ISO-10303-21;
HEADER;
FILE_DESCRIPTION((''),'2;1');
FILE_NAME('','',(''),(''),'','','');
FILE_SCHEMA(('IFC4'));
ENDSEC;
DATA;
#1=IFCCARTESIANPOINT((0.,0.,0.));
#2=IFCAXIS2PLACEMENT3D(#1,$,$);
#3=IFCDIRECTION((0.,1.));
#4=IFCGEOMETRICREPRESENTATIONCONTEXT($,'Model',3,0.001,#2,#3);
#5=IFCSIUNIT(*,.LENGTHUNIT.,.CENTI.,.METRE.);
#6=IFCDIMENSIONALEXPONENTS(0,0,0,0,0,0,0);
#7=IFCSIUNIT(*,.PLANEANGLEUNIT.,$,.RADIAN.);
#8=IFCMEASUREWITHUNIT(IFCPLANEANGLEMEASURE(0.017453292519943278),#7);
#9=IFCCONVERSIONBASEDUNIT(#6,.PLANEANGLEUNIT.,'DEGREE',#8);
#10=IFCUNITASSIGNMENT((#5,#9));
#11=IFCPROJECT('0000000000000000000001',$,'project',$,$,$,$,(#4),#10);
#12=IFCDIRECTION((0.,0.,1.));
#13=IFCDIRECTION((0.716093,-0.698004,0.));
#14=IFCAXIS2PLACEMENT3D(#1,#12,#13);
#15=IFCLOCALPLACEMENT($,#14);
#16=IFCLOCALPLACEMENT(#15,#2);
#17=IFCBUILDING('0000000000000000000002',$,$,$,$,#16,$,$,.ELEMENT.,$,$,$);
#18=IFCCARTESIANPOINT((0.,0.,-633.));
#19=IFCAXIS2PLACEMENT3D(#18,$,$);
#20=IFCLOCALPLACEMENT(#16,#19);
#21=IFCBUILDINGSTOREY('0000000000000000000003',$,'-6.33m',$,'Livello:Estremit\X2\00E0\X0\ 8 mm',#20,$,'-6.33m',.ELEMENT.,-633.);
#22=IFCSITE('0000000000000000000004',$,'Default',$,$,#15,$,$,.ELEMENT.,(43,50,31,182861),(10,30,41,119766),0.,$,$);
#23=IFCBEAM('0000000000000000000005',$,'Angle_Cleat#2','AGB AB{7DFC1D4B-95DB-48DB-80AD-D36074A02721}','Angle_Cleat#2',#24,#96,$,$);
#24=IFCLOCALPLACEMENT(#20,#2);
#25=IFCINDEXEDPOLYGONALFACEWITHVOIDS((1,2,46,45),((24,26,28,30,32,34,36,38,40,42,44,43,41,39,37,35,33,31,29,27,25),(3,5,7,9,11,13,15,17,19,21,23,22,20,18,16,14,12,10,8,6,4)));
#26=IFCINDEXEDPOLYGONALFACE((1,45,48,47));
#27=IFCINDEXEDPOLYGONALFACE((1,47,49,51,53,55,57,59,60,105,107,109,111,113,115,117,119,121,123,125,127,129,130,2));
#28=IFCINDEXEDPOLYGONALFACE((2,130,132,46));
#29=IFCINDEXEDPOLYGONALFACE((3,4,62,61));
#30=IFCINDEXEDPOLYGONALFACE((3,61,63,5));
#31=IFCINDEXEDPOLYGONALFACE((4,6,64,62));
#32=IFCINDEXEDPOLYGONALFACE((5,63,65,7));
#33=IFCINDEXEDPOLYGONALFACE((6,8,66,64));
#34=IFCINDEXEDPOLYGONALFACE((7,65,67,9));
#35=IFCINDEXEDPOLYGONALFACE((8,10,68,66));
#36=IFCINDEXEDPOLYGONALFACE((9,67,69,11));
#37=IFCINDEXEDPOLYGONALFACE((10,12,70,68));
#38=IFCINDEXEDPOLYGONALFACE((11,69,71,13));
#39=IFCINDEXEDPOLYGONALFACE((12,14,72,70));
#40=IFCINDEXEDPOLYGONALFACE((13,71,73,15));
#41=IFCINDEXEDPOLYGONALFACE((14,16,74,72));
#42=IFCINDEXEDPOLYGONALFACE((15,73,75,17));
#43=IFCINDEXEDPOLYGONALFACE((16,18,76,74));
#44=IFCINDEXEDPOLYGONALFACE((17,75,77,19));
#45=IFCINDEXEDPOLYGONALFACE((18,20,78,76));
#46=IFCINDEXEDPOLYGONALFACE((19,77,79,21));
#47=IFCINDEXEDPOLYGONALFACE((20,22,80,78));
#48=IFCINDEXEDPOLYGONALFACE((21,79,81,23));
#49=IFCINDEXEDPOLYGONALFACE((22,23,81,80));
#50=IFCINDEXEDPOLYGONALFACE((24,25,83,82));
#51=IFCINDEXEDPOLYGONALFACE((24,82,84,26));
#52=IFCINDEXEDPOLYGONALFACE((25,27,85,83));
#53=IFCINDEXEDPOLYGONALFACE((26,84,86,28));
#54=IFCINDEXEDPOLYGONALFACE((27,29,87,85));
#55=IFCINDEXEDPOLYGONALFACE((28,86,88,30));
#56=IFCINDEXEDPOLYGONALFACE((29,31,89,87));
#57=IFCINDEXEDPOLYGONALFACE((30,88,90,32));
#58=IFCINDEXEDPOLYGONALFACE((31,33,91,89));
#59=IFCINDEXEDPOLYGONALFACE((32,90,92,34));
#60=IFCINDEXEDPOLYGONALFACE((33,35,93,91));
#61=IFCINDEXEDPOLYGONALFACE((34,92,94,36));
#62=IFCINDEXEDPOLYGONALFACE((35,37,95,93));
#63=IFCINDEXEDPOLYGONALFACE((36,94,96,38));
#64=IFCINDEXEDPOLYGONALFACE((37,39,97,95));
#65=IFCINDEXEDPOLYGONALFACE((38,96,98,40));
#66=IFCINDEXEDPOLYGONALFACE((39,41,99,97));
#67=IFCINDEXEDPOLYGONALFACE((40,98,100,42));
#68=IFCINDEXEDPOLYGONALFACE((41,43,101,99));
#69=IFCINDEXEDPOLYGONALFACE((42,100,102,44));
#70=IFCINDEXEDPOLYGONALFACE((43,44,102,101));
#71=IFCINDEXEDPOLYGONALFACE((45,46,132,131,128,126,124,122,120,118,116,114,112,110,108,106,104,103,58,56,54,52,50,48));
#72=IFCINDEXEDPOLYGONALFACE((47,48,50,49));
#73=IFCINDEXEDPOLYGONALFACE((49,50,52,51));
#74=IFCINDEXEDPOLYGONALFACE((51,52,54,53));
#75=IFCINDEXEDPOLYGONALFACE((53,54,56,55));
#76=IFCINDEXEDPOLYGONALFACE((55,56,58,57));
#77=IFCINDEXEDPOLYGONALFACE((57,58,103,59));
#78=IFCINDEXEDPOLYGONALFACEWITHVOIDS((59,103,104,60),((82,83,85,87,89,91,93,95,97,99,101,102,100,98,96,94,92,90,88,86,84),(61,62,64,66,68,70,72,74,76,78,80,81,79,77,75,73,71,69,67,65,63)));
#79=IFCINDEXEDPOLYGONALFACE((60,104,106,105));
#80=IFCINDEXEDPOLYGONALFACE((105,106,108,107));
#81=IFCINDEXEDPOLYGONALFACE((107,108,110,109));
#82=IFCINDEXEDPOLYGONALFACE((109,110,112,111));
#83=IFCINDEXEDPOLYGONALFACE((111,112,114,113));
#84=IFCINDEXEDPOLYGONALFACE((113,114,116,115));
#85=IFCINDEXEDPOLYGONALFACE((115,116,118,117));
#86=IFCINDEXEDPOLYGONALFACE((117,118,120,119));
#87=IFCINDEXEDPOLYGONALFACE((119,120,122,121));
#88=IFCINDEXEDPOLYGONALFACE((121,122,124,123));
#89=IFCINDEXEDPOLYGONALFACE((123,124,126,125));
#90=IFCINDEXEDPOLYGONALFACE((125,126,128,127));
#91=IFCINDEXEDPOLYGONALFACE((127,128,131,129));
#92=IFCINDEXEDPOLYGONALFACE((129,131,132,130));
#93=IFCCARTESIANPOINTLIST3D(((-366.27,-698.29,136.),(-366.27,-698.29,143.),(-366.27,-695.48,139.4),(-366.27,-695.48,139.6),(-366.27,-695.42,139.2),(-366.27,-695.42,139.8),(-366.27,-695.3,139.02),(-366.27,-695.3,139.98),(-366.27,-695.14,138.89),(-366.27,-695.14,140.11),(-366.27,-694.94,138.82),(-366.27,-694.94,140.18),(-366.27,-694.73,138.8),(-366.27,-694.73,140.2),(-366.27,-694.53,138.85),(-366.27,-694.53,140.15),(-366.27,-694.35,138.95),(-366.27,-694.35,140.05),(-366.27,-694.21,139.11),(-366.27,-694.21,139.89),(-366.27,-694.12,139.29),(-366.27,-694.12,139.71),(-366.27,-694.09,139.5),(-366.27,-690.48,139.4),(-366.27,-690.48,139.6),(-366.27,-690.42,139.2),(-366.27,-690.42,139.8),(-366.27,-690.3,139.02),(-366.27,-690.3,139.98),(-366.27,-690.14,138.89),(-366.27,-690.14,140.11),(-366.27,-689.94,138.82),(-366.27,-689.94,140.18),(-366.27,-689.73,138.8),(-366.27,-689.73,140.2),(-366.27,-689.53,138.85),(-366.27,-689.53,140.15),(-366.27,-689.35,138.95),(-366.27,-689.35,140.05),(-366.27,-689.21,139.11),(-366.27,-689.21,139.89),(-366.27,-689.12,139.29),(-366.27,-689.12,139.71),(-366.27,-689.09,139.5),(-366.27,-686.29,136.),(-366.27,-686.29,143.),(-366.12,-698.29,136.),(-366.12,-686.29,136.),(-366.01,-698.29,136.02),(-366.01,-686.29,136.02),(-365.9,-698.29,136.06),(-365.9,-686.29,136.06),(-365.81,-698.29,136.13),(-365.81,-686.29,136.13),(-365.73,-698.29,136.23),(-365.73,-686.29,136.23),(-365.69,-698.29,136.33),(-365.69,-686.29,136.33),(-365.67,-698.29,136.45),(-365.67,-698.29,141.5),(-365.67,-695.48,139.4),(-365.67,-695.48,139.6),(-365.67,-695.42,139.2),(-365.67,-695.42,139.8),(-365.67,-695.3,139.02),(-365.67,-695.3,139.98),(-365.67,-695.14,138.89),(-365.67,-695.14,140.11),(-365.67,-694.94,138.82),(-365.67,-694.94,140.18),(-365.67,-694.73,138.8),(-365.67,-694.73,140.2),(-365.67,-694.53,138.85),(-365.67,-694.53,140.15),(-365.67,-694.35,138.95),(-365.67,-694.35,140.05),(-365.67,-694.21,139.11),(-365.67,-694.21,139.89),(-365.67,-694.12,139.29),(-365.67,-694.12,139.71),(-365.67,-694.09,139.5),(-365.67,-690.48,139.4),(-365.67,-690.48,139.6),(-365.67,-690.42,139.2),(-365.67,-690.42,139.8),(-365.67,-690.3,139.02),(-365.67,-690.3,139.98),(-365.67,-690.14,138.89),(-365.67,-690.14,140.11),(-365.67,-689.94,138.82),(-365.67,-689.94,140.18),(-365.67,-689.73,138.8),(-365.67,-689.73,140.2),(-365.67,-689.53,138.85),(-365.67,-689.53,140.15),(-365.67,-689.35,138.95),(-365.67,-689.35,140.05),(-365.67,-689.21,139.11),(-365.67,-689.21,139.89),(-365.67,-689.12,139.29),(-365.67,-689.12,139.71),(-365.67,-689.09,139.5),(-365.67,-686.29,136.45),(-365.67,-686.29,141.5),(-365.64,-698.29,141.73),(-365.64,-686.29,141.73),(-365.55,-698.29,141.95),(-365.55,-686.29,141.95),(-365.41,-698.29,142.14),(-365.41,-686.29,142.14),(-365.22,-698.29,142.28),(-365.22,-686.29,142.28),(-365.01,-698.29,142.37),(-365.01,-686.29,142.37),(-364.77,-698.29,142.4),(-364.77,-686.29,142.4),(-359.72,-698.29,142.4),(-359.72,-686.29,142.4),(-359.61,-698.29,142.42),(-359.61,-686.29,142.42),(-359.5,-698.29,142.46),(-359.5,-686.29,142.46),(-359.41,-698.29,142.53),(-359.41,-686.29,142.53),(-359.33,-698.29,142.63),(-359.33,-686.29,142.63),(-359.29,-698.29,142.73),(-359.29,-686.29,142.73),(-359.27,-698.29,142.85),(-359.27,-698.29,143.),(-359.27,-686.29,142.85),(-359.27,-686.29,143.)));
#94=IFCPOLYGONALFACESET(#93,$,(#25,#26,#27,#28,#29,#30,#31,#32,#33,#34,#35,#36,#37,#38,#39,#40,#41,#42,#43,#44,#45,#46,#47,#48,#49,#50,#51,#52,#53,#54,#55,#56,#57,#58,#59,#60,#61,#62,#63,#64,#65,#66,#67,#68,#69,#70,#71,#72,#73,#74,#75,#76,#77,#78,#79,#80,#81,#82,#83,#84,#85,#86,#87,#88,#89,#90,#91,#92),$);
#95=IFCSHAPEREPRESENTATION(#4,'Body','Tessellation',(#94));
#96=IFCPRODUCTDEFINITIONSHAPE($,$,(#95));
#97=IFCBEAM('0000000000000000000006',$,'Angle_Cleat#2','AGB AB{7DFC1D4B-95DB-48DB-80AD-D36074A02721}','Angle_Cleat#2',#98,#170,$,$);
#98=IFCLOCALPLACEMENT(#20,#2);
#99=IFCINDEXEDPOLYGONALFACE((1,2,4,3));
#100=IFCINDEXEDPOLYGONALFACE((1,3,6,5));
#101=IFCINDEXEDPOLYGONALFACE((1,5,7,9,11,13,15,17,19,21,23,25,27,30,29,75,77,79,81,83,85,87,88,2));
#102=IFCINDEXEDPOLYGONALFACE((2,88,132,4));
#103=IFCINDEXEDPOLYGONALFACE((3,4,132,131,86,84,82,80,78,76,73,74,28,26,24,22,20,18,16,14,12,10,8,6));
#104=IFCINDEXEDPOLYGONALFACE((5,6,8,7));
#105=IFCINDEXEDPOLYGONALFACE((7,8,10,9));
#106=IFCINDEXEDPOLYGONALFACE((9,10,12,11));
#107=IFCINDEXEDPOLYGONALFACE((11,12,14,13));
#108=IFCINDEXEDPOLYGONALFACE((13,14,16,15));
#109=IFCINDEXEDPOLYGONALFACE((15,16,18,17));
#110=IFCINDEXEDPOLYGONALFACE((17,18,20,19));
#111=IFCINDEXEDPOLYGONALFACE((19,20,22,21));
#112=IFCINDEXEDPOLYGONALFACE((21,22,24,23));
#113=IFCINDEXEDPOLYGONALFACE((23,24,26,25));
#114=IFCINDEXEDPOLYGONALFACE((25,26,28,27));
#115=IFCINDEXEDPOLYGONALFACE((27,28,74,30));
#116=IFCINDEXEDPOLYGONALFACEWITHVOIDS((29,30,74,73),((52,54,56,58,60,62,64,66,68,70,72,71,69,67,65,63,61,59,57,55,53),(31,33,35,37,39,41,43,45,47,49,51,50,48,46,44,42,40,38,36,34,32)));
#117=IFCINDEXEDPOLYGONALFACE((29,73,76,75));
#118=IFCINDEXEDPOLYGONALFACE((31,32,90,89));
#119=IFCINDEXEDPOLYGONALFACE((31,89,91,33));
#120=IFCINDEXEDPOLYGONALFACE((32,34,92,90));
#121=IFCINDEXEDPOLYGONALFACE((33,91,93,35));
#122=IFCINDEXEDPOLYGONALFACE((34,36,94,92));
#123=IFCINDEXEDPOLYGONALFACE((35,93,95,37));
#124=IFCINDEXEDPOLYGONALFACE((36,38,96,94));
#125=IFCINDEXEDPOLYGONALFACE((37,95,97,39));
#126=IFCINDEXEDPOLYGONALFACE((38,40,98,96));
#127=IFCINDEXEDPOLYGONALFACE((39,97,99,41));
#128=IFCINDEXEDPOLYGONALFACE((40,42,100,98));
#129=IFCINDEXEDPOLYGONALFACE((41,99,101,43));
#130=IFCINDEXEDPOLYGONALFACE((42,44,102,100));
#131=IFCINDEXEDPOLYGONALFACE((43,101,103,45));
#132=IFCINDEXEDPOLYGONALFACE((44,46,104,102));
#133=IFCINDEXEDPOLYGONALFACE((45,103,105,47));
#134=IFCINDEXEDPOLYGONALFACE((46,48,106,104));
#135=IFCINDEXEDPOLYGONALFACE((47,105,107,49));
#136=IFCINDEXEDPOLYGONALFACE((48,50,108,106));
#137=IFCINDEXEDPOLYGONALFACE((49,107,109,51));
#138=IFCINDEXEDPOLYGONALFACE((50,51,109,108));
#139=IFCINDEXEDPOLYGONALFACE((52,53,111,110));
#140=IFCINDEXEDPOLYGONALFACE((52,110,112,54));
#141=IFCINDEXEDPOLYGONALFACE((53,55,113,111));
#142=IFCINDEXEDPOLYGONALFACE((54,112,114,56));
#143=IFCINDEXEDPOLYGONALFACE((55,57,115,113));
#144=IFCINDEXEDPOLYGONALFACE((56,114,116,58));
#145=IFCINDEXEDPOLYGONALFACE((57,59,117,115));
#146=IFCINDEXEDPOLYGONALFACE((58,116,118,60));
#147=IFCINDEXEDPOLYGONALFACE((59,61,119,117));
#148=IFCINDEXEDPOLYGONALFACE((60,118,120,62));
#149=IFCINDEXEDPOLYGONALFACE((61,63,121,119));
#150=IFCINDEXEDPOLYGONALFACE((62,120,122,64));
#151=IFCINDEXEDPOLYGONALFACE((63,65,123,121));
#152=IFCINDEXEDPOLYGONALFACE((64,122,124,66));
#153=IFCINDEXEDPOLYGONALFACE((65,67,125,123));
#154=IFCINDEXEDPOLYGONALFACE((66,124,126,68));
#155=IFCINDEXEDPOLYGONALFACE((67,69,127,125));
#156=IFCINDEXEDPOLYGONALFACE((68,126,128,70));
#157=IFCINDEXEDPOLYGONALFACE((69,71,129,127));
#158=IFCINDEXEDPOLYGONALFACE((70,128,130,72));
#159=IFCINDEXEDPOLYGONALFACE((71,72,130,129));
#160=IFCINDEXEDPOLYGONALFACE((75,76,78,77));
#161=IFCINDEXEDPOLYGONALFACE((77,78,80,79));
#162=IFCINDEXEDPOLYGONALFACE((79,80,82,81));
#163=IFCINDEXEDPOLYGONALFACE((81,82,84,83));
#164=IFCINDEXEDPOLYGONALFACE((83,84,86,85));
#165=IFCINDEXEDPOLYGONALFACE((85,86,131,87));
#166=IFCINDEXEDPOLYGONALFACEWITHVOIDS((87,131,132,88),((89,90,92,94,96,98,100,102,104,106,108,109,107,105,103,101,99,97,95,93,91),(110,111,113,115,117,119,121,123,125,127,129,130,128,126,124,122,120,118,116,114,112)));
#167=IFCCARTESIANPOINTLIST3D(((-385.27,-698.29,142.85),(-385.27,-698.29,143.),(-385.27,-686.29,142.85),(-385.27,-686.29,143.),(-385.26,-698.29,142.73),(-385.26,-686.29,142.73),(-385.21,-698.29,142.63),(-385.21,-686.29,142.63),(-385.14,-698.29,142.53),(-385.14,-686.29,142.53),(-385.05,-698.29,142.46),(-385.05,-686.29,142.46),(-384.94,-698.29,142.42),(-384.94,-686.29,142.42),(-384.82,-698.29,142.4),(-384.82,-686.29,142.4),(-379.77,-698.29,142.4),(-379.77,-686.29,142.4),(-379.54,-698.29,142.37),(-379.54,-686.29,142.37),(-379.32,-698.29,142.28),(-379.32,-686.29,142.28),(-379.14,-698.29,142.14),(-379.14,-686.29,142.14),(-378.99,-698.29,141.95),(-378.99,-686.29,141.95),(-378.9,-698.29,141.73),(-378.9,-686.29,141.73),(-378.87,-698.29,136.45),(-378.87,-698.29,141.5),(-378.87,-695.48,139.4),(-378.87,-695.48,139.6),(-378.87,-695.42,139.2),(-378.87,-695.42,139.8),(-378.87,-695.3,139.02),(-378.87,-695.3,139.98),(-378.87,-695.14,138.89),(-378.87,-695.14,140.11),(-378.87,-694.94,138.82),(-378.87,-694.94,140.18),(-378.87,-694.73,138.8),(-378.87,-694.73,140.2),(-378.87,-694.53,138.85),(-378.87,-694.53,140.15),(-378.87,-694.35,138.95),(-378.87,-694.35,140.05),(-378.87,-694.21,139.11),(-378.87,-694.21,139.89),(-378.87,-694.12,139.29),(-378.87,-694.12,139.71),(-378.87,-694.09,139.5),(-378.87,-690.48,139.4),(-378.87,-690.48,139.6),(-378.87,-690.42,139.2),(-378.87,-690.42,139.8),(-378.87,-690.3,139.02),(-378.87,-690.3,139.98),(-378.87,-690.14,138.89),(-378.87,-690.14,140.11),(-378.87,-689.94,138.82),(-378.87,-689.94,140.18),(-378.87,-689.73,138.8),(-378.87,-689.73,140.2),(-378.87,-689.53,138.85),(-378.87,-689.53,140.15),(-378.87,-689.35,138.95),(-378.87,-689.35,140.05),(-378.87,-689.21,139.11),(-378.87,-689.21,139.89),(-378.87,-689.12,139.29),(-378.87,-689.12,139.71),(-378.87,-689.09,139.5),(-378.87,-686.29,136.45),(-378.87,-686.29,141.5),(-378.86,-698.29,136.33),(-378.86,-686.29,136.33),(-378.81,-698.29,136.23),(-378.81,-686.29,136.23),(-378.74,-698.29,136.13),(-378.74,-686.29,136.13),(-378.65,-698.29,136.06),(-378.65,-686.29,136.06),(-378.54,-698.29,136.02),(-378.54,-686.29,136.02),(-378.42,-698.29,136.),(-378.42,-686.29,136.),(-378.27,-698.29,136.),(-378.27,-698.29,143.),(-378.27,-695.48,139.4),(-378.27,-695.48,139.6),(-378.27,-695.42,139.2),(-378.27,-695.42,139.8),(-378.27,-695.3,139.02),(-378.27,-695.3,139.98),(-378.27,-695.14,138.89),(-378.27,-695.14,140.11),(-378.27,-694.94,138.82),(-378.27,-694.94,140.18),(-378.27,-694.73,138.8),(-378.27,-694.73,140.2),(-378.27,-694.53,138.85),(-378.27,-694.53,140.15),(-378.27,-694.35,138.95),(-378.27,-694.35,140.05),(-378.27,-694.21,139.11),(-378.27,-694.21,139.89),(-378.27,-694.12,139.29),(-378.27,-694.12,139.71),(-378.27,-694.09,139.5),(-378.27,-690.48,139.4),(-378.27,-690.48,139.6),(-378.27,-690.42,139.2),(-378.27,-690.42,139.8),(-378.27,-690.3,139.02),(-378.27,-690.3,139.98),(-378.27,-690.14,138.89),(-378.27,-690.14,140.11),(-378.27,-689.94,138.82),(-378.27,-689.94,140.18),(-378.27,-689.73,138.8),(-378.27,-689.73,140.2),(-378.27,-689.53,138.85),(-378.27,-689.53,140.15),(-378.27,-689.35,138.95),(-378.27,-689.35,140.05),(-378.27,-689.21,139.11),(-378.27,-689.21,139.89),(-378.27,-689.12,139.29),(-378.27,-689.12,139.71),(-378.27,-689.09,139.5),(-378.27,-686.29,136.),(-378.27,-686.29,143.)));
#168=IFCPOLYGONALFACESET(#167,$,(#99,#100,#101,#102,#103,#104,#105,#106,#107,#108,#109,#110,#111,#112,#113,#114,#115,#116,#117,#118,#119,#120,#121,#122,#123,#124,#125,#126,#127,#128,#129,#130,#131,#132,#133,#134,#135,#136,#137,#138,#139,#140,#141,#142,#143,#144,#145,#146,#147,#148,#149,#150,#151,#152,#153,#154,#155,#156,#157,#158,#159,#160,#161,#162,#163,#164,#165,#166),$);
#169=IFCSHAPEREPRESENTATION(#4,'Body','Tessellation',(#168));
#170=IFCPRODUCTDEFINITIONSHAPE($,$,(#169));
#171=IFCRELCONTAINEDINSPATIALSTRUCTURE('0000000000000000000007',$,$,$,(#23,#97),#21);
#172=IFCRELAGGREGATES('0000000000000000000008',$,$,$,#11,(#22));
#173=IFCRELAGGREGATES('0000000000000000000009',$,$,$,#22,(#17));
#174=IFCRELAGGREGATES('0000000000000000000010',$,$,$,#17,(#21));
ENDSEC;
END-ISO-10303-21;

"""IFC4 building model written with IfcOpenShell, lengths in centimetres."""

from ifc_helpers import new_model, entity, si_unit, converted_unit, direction, frame, frame_2d, origin, place, context, project, spatial, circle, l_section, extrude, element, save


model = new_model("IFC4")

# Units and contexts
model_context = context("Model", 3, precision=0.001, world=origin(), true_north=direction((0.0, 1.0)))
ifc_project = project(units=[si_unit("LENGTHUNIT", "METRE", prefix="CENTI"), converted_unit("PLANEANGLEUNIT", "DEGREE", entity("IfcPlaneAngleMeasure", 0.017453292519943278), si_unit("PLANEANGLEUNIT", "RADIAN"), dimensions=[0, 0, 0, 0, 0, 0, 0])], contexts=[model_context])

# Site, building, storey
site_placement = place(None, frame((0.0, 0.0, 0.0), z_axis=(0.0, 0.0, 1.0), x_axis=(0.716093, -0.698004, 0.0)))
site = spatial("IfcSite", under=ifc_project, at=site_placement, Name="Default", CompositionType="ELEMENT", RefLatitude=(43, 50, 31, 182861), RefLongitude=(10, 30, 41, 119766), RefElevation=0.0)
building_placement = place(site_placement, origin())
building = spatial("IfcBuilding", under=site, at=building_placement, CompositionType="ELEMENT")
storey_placement = place(building_placement, frame((0.0, 0.0, -633.0)))
storey = spatial("IfcBuildingStorey", under=building, at=storey_placement, Name="-6.33m", ObjectType="Livello:Estremità 8 mm", LongName="-6.33m", CompositionType="ELEMENT", Elevation=-633.0)

# Beams, openings
beam_1_placement = place(storey_placement, frame((-364.34, -686.29, 141.07), z_axis=(0.0, 1.0, 0.0), x_axis=(1.0, 0.0, 0.0)))
beam_1 = element("IfcBeam", 1, at=beam_1_placement, inside=storey, Name="Angle_Cleat#2", Description="AGB AB{7DFC1D4B-95DB-48DB-80AD-D36074A02721}", ObjectType="Angle_Cleat#2", context=model_context, shape_type="SweptSolid", body=[
    extrude(l_section(Depth=7.0, Width=7.0, Thickness=0.6, FilletRadius=0.9, EdgeRadius=0.45, at=frame_2d((1.57, 1.57))), origin(), (0.0, 0.0, -1.0), 12.0),
])
opening_1_placement = place(beam_1_placement, frame((-1.98, 1.57, -6.0), z_axis=(1.0, 0.0, 0.0), x_axis=(0.0, 0.0, 1.0)))
element("IfcOpeningElement", 2, at=opening_1_placement, cuts=beam_1, ObjectType="Opening", context=model_context, shape_type="SweptSolid", body=[
    extrude(circle(Radius=0.7, at=frame_2d((2.5, 0.0), x_axis=(1.0, 0.0))), origin(), (0.0, 0.0, 1.0), 0.7),
])
opening_2_placement = place(beam_1_placement, frame((-1.98, 1.57, -6.0), z_axis=(1.0, 0.0, 0.0), x_axis=(0.0, 0.0, 1.0)))
element("IfcOpeningElement", 3, at=opening_2_placement, cuts=beam_1, ObjectType="Opening", context=model_context, shape_type="SweptSolid", body=[
    extrude(circle(Radius=0.7, at=frame_2d((-2.5, 0.0), x_axis=(1.0, 0.0))), origin(), (0.0, 0.0, 1.0), 0.7),
])
beam_2_placement = place(storey_placement, frame((-380.2, -698.29, 141.07), z_axis=(0.0, -1.0, 0.0), x_axis=(-1.0, 0.0, 0.0)))
beam_2 = element("IfcBeam", 4, at=beam_2_placement, inside=storey, Name="Angle_Cleat#2", Description="AGB AB{7DFC1D4B-95DB-48DB-80AD-D36074A02721}", ObjectType="Angle_Cleat#2", context=model_context, shape_type="SweptSolid", body=[
    extrude(l_section(Depth=7.0, Width=7.0, Thickness=0.6, FilletRadius=0.9, EdgeRadius=0.45, at=frame_2d((1.57, 1.57))), origin(), (0.0, 0.0, -1.0), 12.0),
])
opening_3_placement = place(beam_2_placement, frame((-1.28, 1.57, -6.0), z_axis=(-1.0, 0.0, 0.0), x_axis=(0.0, 0.0, -1.0)))
element("IfcOpeningElement", 5, at=opening_3_placement, cuts=beam_2, ObjectType="Opening", context=model_context, shape_type="SweptSolid", body=[
    extrude(circle(Radius=0.7, at=frame_2d((2.5, 0.0), x_axis=(1.0, 0.0))), origin(), (0.0, 0.0, 1.0), 0.7),
])
opening_4_placement = place(beam_2_placement, frame((-1.28, 1.57, -6.0), z_axis=(-1.0, 0.0, 0.0), x_axis=(0.0, 0.0, -1.0)))
element("IfcOpeningElement", 6, at=opening_4_placement, cuts=beam_2, ObjectType="Opening", context=model_context, shape_type="SweptSolid", body=[
    extrude(circle(Radius=0.7, at=frame_2d((-2.5, 0.0), x_axis=(1.0, 0.0))), origin(), (0.0, 0.0, 1.0), 0.7),
])

save(model, "model.ifc")
